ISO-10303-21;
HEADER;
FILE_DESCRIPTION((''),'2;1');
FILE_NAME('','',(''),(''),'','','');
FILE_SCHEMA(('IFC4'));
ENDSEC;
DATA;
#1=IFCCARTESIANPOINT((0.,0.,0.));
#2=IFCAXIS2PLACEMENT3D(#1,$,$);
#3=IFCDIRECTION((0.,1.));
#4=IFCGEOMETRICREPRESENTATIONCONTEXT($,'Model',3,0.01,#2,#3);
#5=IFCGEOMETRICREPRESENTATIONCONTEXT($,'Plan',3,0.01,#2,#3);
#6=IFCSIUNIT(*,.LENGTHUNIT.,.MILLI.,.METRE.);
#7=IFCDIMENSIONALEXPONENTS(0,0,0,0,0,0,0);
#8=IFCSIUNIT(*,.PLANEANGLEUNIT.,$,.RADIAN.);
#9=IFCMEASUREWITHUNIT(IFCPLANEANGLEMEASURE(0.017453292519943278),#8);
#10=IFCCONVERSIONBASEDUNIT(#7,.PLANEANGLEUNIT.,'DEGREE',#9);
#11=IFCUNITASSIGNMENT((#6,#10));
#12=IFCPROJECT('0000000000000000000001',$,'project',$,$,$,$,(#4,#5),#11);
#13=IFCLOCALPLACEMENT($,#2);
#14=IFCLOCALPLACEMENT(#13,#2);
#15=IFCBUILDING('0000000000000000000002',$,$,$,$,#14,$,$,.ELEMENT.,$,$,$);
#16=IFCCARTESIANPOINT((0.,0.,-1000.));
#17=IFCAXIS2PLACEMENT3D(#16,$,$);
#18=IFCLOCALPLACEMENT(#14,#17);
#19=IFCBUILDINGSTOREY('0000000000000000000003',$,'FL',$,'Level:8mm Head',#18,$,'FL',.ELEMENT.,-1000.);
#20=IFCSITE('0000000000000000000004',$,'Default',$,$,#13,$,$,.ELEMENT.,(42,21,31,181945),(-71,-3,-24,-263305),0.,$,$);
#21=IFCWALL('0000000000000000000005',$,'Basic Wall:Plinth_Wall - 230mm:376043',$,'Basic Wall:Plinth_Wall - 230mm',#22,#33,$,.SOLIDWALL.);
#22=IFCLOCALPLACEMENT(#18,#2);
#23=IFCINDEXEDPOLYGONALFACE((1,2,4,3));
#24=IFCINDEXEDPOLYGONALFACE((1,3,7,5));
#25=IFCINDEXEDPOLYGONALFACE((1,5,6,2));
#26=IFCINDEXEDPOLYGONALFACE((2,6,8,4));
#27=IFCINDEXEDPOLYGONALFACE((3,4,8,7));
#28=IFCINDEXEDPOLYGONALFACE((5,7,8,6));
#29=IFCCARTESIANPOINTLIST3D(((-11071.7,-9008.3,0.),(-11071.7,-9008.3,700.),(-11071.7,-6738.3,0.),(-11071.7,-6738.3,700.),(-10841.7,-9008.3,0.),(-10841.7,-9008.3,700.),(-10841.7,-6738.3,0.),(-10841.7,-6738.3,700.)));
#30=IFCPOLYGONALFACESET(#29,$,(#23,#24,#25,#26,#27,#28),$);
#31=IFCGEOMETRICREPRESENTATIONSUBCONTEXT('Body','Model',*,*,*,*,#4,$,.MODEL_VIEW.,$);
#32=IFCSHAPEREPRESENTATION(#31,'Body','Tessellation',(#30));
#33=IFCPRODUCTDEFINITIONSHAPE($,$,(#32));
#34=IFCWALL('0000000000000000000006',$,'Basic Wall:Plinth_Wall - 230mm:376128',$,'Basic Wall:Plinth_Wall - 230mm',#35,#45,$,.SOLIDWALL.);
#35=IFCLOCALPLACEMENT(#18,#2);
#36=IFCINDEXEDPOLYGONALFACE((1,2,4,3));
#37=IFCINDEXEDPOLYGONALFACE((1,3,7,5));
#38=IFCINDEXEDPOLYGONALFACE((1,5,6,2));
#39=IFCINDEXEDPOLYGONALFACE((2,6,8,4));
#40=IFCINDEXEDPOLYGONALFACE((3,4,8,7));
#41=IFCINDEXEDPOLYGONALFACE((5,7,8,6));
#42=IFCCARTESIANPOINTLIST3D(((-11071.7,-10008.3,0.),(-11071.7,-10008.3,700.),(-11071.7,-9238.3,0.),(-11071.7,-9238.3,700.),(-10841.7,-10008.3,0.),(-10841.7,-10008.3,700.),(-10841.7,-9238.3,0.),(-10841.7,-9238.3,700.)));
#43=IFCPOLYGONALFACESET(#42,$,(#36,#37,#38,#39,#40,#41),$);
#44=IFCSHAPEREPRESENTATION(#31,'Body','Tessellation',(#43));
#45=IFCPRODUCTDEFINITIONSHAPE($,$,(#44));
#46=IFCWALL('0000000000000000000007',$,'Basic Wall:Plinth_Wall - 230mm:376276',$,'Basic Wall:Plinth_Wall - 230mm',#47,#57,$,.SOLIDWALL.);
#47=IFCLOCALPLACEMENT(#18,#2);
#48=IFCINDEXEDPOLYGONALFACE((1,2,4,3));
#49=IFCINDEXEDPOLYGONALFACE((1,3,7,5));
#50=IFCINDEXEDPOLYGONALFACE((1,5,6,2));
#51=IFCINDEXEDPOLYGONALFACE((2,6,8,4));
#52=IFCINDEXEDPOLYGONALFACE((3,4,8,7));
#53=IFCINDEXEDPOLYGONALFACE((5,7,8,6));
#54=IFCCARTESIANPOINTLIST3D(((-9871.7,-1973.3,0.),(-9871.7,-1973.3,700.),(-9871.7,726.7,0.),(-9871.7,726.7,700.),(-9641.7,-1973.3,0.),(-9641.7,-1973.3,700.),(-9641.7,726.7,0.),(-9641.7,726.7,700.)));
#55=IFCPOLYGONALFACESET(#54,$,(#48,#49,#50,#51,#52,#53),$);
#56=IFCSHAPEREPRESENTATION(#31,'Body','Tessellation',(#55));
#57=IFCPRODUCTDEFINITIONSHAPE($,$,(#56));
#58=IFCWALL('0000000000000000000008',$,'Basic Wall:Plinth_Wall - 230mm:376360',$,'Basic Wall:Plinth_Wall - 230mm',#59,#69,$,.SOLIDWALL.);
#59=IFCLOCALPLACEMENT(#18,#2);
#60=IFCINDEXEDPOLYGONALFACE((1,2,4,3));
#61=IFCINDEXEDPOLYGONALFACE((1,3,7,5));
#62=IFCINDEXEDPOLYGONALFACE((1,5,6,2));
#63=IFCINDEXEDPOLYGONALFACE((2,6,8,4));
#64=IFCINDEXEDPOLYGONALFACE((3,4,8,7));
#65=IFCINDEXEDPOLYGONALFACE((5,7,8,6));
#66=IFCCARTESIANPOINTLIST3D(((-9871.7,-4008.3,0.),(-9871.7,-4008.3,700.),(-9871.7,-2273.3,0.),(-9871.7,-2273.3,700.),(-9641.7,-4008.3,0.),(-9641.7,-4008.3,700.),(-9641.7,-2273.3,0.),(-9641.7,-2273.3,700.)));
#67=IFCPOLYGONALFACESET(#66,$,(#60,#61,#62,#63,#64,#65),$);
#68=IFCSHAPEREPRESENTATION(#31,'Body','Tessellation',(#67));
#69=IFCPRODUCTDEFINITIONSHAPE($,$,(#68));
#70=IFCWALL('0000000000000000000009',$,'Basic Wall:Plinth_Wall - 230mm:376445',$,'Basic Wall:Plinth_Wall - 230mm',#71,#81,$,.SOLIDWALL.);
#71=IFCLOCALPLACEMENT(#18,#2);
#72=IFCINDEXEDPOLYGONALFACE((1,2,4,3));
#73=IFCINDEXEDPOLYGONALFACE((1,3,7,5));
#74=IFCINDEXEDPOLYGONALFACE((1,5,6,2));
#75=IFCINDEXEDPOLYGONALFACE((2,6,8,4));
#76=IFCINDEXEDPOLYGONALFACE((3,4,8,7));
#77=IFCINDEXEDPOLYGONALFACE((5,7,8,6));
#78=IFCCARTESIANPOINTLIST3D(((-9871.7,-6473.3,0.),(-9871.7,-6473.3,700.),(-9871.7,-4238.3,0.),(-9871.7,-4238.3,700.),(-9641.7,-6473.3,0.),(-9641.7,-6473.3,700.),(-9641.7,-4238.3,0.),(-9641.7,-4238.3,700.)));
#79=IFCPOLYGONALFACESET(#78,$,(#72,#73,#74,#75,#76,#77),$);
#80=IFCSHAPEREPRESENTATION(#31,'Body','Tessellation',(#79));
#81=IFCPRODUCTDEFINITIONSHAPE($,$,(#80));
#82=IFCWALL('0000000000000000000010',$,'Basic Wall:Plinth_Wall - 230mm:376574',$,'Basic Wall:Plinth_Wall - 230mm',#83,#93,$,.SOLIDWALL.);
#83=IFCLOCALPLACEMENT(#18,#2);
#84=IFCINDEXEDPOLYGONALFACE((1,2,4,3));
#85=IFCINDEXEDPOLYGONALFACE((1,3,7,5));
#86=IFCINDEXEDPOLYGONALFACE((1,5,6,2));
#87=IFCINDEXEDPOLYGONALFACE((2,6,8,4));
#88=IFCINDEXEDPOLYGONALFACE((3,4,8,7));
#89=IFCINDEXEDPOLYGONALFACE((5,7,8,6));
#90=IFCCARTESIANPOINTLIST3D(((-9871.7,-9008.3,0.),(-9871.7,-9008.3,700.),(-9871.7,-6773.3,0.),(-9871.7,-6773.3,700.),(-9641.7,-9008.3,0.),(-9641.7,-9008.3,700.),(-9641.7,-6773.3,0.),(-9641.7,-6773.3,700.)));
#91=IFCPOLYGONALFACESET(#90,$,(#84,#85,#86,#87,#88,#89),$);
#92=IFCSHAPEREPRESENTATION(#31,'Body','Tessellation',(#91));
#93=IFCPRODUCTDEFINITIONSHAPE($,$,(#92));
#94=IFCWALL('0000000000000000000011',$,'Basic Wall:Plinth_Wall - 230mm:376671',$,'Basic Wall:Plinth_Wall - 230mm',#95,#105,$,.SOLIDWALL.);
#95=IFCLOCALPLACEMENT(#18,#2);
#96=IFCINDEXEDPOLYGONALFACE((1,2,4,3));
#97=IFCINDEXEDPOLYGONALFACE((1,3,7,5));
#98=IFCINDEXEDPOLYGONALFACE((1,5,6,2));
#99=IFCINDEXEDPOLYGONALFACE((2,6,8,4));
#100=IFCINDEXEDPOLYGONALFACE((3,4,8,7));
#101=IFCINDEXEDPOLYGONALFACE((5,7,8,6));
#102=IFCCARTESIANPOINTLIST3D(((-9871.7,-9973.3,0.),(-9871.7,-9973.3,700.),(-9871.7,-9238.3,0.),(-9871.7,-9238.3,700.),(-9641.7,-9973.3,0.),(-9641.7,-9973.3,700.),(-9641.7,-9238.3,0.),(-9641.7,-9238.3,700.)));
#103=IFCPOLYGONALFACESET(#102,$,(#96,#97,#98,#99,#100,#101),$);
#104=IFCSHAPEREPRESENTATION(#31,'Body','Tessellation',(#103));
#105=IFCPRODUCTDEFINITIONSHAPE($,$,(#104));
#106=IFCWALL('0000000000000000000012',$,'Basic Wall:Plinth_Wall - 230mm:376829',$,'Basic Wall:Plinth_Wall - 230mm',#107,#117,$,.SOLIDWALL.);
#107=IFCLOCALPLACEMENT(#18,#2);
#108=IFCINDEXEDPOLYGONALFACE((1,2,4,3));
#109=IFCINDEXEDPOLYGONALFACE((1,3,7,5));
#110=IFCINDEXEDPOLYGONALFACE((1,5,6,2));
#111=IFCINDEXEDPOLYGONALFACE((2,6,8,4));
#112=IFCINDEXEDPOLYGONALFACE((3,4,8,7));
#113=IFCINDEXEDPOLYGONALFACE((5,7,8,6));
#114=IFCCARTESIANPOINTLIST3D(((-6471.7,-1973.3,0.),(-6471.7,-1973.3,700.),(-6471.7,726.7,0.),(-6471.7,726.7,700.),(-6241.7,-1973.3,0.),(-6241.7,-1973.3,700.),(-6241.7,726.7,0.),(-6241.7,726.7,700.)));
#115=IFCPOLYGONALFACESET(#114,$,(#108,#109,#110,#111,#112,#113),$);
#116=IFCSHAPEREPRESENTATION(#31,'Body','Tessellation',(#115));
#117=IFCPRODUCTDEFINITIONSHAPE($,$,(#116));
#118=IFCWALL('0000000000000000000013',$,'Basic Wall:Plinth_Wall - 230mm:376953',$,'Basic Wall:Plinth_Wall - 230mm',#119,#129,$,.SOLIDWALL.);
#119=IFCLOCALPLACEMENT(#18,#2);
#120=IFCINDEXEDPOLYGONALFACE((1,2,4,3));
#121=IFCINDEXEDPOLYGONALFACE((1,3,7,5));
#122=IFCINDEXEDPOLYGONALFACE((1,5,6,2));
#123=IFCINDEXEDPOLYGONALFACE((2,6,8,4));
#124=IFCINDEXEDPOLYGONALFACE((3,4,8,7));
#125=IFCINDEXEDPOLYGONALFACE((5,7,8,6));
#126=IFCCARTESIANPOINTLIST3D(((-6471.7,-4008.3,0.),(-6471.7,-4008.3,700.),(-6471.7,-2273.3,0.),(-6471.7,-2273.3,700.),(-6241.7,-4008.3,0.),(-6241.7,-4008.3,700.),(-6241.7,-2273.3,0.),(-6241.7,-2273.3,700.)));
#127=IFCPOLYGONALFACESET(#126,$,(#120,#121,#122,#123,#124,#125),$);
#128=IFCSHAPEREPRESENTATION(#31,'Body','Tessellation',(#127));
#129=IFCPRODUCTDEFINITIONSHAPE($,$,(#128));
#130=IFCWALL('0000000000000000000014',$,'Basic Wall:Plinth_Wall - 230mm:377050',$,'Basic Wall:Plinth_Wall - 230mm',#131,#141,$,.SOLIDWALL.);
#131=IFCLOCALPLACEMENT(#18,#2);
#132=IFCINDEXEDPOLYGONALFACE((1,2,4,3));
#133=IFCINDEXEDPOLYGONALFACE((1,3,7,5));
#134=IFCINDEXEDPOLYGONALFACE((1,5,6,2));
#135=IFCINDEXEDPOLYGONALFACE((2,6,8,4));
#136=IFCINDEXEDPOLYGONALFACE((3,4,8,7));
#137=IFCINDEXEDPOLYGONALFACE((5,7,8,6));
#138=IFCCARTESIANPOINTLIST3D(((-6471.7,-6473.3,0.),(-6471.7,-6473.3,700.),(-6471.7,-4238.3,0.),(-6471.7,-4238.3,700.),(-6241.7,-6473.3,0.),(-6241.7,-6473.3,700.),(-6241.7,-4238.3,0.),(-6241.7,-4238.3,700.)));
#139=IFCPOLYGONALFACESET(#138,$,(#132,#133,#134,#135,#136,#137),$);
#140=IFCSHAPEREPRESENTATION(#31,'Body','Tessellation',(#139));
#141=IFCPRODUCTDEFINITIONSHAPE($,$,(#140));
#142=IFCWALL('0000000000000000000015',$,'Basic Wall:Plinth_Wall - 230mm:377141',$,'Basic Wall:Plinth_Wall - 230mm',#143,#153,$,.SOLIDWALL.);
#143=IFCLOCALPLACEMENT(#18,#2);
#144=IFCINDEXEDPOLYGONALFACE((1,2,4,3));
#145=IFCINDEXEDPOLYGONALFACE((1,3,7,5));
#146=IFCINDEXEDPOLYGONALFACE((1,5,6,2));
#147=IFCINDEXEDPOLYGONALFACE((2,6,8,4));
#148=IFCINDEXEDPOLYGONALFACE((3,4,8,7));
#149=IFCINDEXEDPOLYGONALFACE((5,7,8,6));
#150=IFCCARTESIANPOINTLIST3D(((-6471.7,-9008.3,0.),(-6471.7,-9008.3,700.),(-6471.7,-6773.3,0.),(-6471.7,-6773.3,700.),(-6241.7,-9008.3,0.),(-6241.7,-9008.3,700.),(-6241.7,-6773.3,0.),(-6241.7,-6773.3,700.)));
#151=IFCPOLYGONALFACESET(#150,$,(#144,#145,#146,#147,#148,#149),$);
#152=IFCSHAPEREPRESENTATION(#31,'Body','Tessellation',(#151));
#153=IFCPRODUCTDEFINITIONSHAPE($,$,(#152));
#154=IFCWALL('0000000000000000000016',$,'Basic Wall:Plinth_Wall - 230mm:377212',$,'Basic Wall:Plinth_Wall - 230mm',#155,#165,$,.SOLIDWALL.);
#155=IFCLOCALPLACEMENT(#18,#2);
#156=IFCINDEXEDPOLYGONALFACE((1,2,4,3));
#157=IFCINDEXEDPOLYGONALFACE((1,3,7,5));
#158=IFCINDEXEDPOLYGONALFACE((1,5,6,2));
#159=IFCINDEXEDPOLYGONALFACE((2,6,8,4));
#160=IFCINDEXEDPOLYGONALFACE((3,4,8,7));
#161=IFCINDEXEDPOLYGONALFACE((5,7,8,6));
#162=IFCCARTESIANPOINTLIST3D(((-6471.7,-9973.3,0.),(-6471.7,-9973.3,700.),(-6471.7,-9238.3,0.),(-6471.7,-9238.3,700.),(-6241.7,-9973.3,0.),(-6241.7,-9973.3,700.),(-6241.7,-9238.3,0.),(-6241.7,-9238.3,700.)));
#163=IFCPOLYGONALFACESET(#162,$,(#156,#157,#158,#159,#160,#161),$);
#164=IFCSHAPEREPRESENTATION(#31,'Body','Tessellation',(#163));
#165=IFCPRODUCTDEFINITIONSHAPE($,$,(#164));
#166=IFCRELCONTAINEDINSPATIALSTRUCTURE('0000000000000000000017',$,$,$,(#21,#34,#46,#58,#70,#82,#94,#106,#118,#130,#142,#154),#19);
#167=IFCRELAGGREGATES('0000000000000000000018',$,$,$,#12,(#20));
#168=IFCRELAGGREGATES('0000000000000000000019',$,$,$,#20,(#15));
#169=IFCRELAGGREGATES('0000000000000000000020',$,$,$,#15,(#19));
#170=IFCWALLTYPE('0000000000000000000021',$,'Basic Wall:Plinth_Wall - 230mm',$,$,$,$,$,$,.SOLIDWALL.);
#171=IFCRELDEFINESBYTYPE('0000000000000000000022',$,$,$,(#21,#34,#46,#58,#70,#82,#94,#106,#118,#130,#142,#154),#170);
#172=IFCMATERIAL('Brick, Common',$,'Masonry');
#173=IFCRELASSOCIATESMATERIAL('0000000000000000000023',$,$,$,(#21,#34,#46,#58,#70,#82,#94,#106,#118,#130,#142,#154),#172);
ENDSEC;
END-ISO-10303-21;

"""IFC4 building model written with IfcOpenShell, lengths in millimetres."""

from ifc_helpers import new_model, entity, si_unit, converted_unit, direction, frame, origin, place, context, subcontext, project, spatial, indexed_curve, outline, extrude, material, type_object, element, save


model = new_model("IFC4")

# Units and contexts
model_context = context("Model", 3, precision=0.01, world=origin(), true_north=direction((0.0, 1.0)))
plan_context = context("Plan", 3, precision=0.01, world=origin(), true_north=direction((0.0, 1.0)))
body_context = subcontext(model_context, "Body", "Model", "MODEL_VIEW")
ifc_project = project(units=[si_unit("LENGTHUNIT", "METRE", prefix="MILLI"), converted_unit("PLANEANGLEUNIT", "DEGREE", entity("IfcPlaneAngleMeasure", 0.017453292519943278), si_unit("PLANEANGLEUNIT", "RADIAN"), dimensions=[0, 0, 0, 0, 0, 0, 0])], contexts=[model_context, plan_context])

# Site, building, storey
site_placement = place(None, origin())
site = spatial("IfcSite", under=ifc_project, at=site_placement, Name="Default", CompositionType="ELEMENT", RefLatitude=(42, 21, 31, 181945), RefLongitude=(-71, -3, -24, -263305), RefElevation=0.0)
building_placement = place(site_placement, origin())
building = spatial("IfcBuilding", under=site, at=building_placement, CompositionType="ELEMENT")
storey_placement = place(building_placement, frame((0.0, 0.0, -1000.0)))
storey = spatial("IfcBuildingStorey", under=building, at=storey_placement, Name="FL", ObjectType="Level:8mm Head", LongName="FL", CompositionType="ELEMENT", Elevation=-1000.0)

# Walls
ifc_material = material(Name="Brick, Common", Category="Masonry")
wall_type = type_object("IfcWallType", Name="Basic Wall:Plinth_Wall - 230mm", PredefinedType="SOLIDWALL")
wall_1_placement = place(storey_placement, frame((-10956.7, -6738.3, 0.0), z_axis=(0.0, 0.0, 1.0), x_axis=(0.0, -1.0, 0.0)))
element("IfcWall", 1, at=wall_1_placement, inside=storey, type_object=wall_type, material=ifc_material, Name="Basic Wall:Plinth_Wall - 230mm:376043", ObjectType="Basic Wall:Plinth_Wall - 230mm", PredefinedType="SOLIDWALL", context=body_context, shape_type="SweptSolid", body=[
    extrude(outline(indexed_curve([(2270.0, 115.0), (0.0, 115.0), (0.0, -115.0), (2270.0, -115.0), (2270.0, 115.0)], self_intersect=False)), origin(), (0.0, 0.0, 1.0), 700.0),
])
wall_2_placement = place(storey_placement, frame((-10956.7, -9238.3, 0.0), z_axis=(0.0, 0.0, 1.0), x_axis=(0.0, -1.0, 0.0)))
element("IfcWall", 2, at=wall_2_placement, inside=storey, type_object=wall_type, material=ifc_material, Name="Basic Wall:Plinth_Wall - 230mm:376128", ObjectType="Basic Wall:Plinth_Wall - 230mm", PredefinedType="SOLIDWALL", context=body_context, shape_type="SweptSolid", body=[
    extrude(outline(indexed_curve([(770.0, 115.0), (0.0, 115.0), (0.0, -115.0), (770.0, -115.0), (770.0, 115.0)], self_intersect=False)), origin(), (0.0, 0.0, 1.0), 700.0),
])
wall_3_placement = place(storey_placement, frame((-9756.7, 726.7, 0.0), z_axis=(0.0, 0.0, 1.0), x_axis=(0.0, -1.0, 0.0)))
element("IfcWall", 3, at=wall_3_placement, inside=storey, type_object=wall_type, material=ifc_material, Name="Basic Wall:Plinth_Wall - 230mm:376276", ObjectType="Basic Wall:Plinth_Wall - 230mm", PredefinedType="SOLIDWALL", context=body_context, shape_type="SweptSolid", body=[
    extrude(outline(indexed_curve([(2700.0, 115.0), (0.0, 115.0), (0.0, -115.0), (2700.0, -115.0), (2700.0, 115.0)], self_intersect=False)), origin(), (0.0, 0.0, 1.0), 700.0),
])
wall_4_placement = place(storey_placement, frame((-9756.7, -2273.3, 0.0), z_axis=(0.0, 0.0, 1.0), x_axis=(0.0, -1.0, 0.0)))
element("IfcWall", 4, at=wall_4_placement, inside=storey, type_object=wall_type, material=ifc_material, Name="Basic Wall:Plinth_Wall - 230mm:376360", ObjectType="Basic Wall:Plinth_Wall - 230mm", PredefinedType="SOLIDWALL", context=body_context, shape_type="SweptSolid", body=[
    extrude(outline(indexed_curve([(1735.0, 115.0), (0.0, 115.0), (0.0, -115.0), (1735.0, -115.0), (1735.0, 115.0)], self_intersect=False)), origin(), (0.0, 0.0, 1.0), 700.0),
])
wall_5_placement = place(storey_placement, frame((-9756.7, -4238.3, 0.0), z_axis=(0.0, 0.0, 1.0), x_axis=(0.0, -1.0, 0.0)))
element("IfcWall", 5, at=wall_5_placement, inside=storey, type_object=wall_type, material=ifc_material, Name="Basic Wall:Plinth_Wall - 230mm:376445", ObjectType="Basic Wall:Plinth_Wall - 230mm", PredefinedType="SOLIDWALL", context=body_context, shape_type="SweptSolid", body=[
    extrude(outline(indexed_curve([(2235.0, 115.0), (0.0, 115.0), (0.0, -115.0), (2235.0, -115.0), (2235.0, 115.0)], self_intersect=False)), origin(), (0.0, 0.0, 1.0), 700.0),
])
wall_6_placement = place(storey_placement, frame((-9756.7, -6773.3, 0.0), z_axis=(0.0, 0.0, 1.0), x_axis=(0.0, -1.0, 0.0)))
element("IfcWall", 6, at=wall_6_placement, inside=storey, type_object=wall_type, material=ifc_material, Name="Basic Wall:Plinth_Wall - 230mm:376574", ObjectType="Basic Wall:Plinth_Wall - 230mm", PredefinedType="SOLIDWALL", context=body_context, shape_type="SweptSolid", body=[
    extrude(outline(indexed_curve([(2235.0, 115.0), (0.0, 115.0), (0.0, -115.0), (2235.0, -115.0), (2235.0, 115.0)], self_intersect=False)), origin(), (0.0, 0.0, 1.0), 700.0),
])
wall_7_placement = place(storey_placement, frame((-9756.7, -9238.3, 0.0), z_axis=(0.0, 0.0, 1.0), x_axis=(0.0, -1.0, 0.0)))
element("IfcWall", 7, at=wall_7_placement, inside=storey, type_object=wall_type, material=ifc_material, Name="Basic Wall:Plinth_Wall - 230mm:376671", ObjectType="Basic Wall:Plinth_Wall - 230mm", PredefinedType="SOLIDWALL", context=body_context, shape_type="SweptSolid", body=[
    extrude(outline(indexed_curve([(735.0, 115.0), (0.0, 115.0), (0.0, -115.0), (735.0, -115.0), (735.0, 115.0)], self_intersect=False)), origin(), (0.0, 0.0, 1.0), 700.0),
])
wall_8_placement = place(storey_placement, frame((-6356.7, 726.7, 0.0), z_axis=(0.0, 0.0, 1.0), x_axis=(0.0, -1.0, 0.0)))
element("IfcWall", 8, at=wall_8_placement, inside=storey, type_object=wall_type, material=ifc_material, Name="Basic Wall:Plinth_Wall - 230mm:376829", ObjectType="Basic Wall:Plinth_Wall - 230mm", PredefinedType="SOLIDWALL", context=body_context, shape_type="SweptSolid", body=[
    extrude(outline(indexed_curve([(2700.0, 115.0), (0.0, 115.0), (0.0, -115.0), (2700.0, -115.0), (2700.0, 115.0)], self_intersect=False)), origin(), (0.0, 0.0, 1.0), 700.0),
])
wall_9_placement = place(storey_placement, frame((-6356.7, -2273.3, 0.0), z_axis=(0.0, 0.0, 1.0), x_axis=(0.0, -1.0, 0.0)))
element("IfcWall", 9, at=wall_9_placement, inside=storey, type_object=wall_type, material=ifc_material, Name="Basic Wall:Plinth_Wall - 230mm:376953", ObjectType="Basic Wall:Plinth_Wall - 230mm", PredefinedType="SOLIDWALL", context=body_context, shape_type="SweptSolid", body=[
    extrude(outline(indexed_curve([(1735.0, 115.0), (0.0, 115.0), (0.0, -115.0), (1735.0, -115.0), (1735.0, 115.0)], self_intersect=False)), origin(), (0.0, 0.0, 1.0), 700.0),
])
wall_10_placement = place(storey_placement, frame((-6356.7, -4238.3, 0.0), z_axis=(0.0, 0.0, 1.0), x_axis=(0.0, -1.0, 0.0)))
element("IfcWall", 10, at=wall_10_placement, inside=storey, type_object=wall_type, material=ifc_material, Name="Basic Wall:Plinth_Wall - 230mm:377050", ObjectType="Basic Wall:Plinth_Wall - 230mm", PredefinedType="SOLIDWALL", context=body_context, shape_type="SweptSolid", body=[
    extrude(outline(indexed_curve([(2235.0, 115.0), (0.0, 115.0), (0.0, -115.0), (2235.0, -115.0), (2235.0, 115.0)], self_intersect=False)), origin(), (0.0, 0.0, 1.0), 700.0),
])
wall_11_placement = place(storey_placement, frame((-6356.7, -6773.3, 0.0), z_axis=(0.0, 0.0, 1.0), x_axis=(0.0, -1.0, 0.0)))
element("IfcWall", 11, at=wall_11_placement, inside=storey, type_object=wall_type, material=ifc_material, Name="Basic Wall:Plinth_Wall - 230mm:377141", ObjectType="Basic Wall:Plinth_Wall - 230mm", PredefinedType="SOLIDWALL", context=body_context, shape_type="SweptSolid", body=[
    extrude(outline(indexed_curve([(2235.0, 115.0), (0.0, 115.0), (0.0, -115.0), (2235.0, -115.0), (2235.0, 115.0)], self_intersect=False)), origin(), (0.0, 0.0, 1.0), 700.0),
])
wall_12_placement = place(storey_placement, frame((-6356.7, -9238.3, 0.0), z_axis=(0.0, 0.0, 1.0), x_axis=(0.0, -1.0, 0.0)))
element("IfcWall", 12, at=wall_12_placement, inside=storey, type_object=wall_type, material=ifc_material, Name="Basic Wall:Plinth_Wall - 230mm:377212", ObjectType="Basic Wall:Plinth_Wall - 230mm", PredefinedType="SOLIDWALL", context=body_context, shape_type="SweptSolid", body=[
    extrude(outline(indexed_curve([(735.0, 115.0), (0.0, 115.0), (0.0, -115.0), (735.0, -115.0), (735.0, 115.0)], self_intersect=False)), origin(), (0.0, 0.0, 1.0), 700.0),
])

save(model, "model.ifc")
